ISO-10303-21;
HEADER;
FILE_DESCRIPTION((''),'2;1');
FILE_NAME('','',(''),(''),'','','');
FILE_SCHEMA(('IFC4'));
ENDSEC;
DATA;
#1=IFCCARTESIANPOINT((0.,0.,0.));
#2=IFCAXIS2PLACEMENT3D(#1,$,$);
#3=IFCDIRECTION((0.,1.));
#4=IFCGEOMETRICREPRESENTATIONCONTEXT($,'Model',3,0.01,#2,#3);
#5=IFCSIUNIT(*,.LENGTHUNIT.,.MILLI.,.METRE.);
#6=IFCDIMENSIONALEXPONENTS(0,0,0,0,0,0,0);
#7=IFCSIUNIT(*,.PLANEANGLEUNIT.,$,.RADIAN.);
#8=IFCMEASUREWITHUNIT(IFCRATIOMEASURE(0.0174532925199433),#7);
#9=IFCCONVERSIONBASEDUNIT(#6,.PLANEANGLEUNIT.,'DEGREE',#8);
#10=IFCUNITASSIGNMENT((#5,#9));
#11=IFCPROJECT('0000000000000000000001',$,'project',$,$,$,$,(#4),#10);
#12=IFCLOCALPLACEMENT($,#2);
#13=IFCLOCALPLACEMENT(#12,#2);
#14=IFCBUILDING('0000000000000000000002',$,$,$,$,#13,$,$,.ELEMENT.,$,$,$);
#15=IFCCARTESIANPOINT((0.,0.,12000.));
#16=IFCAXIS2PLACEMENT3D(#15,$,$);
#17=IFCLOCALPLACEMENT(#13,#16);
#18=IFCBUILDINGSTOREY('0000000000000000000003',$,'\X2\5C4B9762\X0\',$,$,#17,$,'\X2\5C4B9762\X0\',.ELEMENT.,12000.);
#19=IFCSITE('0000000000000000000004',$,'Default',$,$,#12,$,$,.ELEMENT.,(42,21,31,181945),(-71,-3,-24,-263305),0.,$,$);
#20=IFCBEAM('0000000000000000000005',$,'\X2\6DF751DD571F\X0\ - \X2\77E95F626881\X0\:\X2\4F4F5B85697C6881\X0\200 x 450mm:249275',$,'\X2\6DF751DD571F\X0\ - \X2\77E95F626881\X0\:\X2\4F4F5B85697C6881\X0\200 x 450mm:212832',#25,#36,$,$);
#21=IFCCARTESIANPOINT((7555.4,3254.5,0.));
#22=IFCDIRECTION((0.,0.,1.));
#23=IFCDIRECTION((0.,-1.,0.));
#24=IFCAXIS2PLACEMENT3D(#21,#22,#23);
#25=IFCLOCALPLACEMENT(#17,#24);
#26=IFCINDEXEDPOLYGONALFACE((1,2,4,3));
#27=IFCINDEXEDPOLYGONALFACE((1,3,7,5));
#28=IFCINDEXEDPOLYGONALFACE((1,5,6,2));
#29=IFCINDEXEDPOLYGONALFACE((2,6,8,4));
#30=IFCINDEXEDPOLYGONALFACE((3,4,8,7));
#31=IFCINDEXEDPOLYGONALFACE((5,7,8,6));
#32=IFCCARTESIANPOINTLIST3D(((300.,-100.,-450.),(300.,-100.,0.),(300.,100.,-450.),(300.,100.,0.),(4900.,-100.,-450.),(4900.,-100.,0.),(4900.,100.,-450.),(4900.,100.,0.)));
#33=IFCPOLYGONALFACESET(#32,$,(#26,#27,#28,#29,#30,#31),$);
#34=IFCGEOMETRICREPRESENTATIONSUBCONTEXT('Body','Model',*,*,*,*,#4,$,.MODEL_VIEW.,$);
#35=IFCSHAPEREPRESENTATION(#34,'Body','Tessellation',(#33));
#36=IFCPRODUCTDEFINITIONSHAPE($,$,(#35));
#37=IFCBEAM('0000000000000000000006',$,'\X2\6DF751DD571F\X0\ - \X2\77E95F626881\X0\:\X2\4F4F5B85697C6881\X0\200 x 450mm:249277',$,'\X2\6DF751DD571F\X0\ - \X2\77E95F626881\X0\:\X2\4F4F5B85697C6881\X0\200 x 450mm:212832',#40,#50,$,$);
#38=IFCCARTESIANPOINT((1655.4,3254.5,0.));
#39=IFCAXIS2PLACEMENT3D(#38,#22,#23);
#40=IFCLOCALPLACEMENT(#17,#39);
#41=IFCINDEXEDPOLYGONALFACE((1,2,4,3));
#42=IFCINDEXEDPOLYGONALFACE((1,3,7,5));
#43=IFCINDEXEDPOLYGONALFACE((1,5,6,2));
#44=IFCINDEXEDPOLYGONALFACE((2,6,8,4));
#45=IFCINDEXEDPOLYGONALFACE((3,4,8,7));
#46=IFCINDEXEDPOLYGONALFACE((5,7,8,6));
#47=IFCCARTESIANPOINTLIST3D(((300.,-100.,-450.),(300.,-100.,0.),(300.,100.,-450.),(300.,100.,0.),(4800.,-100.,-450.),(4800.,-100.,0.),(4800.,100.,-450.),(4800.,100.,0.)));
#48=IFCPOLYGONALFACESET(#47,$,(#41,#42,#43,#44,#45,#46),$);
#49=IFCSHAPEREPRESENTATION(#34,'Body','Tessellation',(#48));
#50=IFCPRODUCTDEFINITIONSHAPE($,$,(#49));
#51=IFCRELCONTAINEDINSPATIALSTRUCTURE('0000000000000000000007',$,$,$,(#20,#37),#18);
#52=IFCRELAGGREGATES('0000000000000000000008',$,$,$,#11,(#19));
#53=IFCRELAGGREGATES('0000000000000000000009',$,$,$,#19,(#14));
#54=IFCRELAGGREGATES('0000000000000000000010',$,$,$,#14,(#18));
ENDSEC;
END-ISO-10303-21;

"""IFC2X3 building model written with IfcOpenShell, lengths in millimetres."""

from ifc_helpers import new_model, entity, si_unit, converted_unit, direction, frame, frame_2d, origin, place, context, subcontext, project, spatial, rectangle, extrude, element, save


model = new_model("IFC2X3")

# Units and contexts
model_context = context("Model", 3, precision=0.01, world=origin(), true_north=direction((0.0, 1.0)))
body_context = subcontext(model_context, "Body", "Model", "MODEL_VIEW")
ifc_project = project(units=[si_unit("LENGTHUNIT", "METRE", prefix="MILLI"), converted_unit("PLANEANGLEUNIT", "DEGREE", entity("IfcRatioMeasure", 0.0174532925199433), si_unit("PLANEANGLEUNIT", "RADIAN"), dimensions=[0, 0, 0, 0, 0, 0, 0])], contexts=[model_context])

# Site, building, storey
site_placement = place(None, origin())
site = spatial("IfcSite", under=ifc_project, at=site_placement, Name="Default", CompositionType="ELEMENT", RefLatitude=(42, 21, 31, 181945), RefLongitude=(-71, -3, -24, -263305), RefElevation=0.0)
building_placement = place(site_placement, origin())
building = spatial("IfcBuilding", under=site, at=building_placement, CompositionType="ELEMENT")
storey_placement = place(building_placement, frame((0.0, 0.0, 12000.0)))
storey = spatial("IfcBuildingStorey", under=building, at=storey_placement, Name="屋面", LongName="屋面", CompositionType="ELEMENT", Elevation=12000.0)

# Beams
beam_1_placement = place(storey_placement, frame((7555.4, 3254.5, 0.0), z_axis=(0.0, 0.0, 1.0), x_axis=(0.0, -1.0, 0.0)))
element("IfcBeam", 1, at=beam_1_placement, inside=storey, Name="混凝土 - 矩形梁:住宅楼梁200 x 450mm:249275", ObjectType="混凝土 - 矩形梁:住宅楼梁200 x 450mm:212832", context=body_context, shape_type="SweptSolid", body=[
    extrude(rectangle(XDim=450.0, YDim=200.0, at=frame_2d((0.0, 0.0), x_axis=(1.0, 0.0))), frame((300.0, 0.0, -225.0), z_axis=(1.0, 0.0, 0.0), x_axis=(0.0, 0.0, -1.0)), (0.0, 0.0, 1.0), 4600.0),
])
beam_2_placement = place(storey_placement, frame((1655.4, 3254.5, 0.0), z_axis=(0.0, 0.0, 1.0), x_axis=(0.0, -1.0, 0.0)))
element("IfcBeam", 2, at=beam_2_placement, inside=storey, Name="混凝土 - 矩形梁:住宅楼梁200 x 450mm:249277", ObjectType="混凝土 - 矩形梁:住宅楼梁200 x 450mm:212832", context=body_context, shape_type="SweptSolid", body=[
    extrude(rectangle(XDim=450.0, YDim=200.0, at=frame_2d((0.0, 0.0), x_axis=(1.0, 0.0))), frame((300.0, 0.0, -225.0), z_axis=(1.0, 0.0, 0.0), x_axis=(0.0, 0.0, -1.0)), (0.0, 0.0, 1.0), 4500.0),
])

save(model, "model.ifc")
